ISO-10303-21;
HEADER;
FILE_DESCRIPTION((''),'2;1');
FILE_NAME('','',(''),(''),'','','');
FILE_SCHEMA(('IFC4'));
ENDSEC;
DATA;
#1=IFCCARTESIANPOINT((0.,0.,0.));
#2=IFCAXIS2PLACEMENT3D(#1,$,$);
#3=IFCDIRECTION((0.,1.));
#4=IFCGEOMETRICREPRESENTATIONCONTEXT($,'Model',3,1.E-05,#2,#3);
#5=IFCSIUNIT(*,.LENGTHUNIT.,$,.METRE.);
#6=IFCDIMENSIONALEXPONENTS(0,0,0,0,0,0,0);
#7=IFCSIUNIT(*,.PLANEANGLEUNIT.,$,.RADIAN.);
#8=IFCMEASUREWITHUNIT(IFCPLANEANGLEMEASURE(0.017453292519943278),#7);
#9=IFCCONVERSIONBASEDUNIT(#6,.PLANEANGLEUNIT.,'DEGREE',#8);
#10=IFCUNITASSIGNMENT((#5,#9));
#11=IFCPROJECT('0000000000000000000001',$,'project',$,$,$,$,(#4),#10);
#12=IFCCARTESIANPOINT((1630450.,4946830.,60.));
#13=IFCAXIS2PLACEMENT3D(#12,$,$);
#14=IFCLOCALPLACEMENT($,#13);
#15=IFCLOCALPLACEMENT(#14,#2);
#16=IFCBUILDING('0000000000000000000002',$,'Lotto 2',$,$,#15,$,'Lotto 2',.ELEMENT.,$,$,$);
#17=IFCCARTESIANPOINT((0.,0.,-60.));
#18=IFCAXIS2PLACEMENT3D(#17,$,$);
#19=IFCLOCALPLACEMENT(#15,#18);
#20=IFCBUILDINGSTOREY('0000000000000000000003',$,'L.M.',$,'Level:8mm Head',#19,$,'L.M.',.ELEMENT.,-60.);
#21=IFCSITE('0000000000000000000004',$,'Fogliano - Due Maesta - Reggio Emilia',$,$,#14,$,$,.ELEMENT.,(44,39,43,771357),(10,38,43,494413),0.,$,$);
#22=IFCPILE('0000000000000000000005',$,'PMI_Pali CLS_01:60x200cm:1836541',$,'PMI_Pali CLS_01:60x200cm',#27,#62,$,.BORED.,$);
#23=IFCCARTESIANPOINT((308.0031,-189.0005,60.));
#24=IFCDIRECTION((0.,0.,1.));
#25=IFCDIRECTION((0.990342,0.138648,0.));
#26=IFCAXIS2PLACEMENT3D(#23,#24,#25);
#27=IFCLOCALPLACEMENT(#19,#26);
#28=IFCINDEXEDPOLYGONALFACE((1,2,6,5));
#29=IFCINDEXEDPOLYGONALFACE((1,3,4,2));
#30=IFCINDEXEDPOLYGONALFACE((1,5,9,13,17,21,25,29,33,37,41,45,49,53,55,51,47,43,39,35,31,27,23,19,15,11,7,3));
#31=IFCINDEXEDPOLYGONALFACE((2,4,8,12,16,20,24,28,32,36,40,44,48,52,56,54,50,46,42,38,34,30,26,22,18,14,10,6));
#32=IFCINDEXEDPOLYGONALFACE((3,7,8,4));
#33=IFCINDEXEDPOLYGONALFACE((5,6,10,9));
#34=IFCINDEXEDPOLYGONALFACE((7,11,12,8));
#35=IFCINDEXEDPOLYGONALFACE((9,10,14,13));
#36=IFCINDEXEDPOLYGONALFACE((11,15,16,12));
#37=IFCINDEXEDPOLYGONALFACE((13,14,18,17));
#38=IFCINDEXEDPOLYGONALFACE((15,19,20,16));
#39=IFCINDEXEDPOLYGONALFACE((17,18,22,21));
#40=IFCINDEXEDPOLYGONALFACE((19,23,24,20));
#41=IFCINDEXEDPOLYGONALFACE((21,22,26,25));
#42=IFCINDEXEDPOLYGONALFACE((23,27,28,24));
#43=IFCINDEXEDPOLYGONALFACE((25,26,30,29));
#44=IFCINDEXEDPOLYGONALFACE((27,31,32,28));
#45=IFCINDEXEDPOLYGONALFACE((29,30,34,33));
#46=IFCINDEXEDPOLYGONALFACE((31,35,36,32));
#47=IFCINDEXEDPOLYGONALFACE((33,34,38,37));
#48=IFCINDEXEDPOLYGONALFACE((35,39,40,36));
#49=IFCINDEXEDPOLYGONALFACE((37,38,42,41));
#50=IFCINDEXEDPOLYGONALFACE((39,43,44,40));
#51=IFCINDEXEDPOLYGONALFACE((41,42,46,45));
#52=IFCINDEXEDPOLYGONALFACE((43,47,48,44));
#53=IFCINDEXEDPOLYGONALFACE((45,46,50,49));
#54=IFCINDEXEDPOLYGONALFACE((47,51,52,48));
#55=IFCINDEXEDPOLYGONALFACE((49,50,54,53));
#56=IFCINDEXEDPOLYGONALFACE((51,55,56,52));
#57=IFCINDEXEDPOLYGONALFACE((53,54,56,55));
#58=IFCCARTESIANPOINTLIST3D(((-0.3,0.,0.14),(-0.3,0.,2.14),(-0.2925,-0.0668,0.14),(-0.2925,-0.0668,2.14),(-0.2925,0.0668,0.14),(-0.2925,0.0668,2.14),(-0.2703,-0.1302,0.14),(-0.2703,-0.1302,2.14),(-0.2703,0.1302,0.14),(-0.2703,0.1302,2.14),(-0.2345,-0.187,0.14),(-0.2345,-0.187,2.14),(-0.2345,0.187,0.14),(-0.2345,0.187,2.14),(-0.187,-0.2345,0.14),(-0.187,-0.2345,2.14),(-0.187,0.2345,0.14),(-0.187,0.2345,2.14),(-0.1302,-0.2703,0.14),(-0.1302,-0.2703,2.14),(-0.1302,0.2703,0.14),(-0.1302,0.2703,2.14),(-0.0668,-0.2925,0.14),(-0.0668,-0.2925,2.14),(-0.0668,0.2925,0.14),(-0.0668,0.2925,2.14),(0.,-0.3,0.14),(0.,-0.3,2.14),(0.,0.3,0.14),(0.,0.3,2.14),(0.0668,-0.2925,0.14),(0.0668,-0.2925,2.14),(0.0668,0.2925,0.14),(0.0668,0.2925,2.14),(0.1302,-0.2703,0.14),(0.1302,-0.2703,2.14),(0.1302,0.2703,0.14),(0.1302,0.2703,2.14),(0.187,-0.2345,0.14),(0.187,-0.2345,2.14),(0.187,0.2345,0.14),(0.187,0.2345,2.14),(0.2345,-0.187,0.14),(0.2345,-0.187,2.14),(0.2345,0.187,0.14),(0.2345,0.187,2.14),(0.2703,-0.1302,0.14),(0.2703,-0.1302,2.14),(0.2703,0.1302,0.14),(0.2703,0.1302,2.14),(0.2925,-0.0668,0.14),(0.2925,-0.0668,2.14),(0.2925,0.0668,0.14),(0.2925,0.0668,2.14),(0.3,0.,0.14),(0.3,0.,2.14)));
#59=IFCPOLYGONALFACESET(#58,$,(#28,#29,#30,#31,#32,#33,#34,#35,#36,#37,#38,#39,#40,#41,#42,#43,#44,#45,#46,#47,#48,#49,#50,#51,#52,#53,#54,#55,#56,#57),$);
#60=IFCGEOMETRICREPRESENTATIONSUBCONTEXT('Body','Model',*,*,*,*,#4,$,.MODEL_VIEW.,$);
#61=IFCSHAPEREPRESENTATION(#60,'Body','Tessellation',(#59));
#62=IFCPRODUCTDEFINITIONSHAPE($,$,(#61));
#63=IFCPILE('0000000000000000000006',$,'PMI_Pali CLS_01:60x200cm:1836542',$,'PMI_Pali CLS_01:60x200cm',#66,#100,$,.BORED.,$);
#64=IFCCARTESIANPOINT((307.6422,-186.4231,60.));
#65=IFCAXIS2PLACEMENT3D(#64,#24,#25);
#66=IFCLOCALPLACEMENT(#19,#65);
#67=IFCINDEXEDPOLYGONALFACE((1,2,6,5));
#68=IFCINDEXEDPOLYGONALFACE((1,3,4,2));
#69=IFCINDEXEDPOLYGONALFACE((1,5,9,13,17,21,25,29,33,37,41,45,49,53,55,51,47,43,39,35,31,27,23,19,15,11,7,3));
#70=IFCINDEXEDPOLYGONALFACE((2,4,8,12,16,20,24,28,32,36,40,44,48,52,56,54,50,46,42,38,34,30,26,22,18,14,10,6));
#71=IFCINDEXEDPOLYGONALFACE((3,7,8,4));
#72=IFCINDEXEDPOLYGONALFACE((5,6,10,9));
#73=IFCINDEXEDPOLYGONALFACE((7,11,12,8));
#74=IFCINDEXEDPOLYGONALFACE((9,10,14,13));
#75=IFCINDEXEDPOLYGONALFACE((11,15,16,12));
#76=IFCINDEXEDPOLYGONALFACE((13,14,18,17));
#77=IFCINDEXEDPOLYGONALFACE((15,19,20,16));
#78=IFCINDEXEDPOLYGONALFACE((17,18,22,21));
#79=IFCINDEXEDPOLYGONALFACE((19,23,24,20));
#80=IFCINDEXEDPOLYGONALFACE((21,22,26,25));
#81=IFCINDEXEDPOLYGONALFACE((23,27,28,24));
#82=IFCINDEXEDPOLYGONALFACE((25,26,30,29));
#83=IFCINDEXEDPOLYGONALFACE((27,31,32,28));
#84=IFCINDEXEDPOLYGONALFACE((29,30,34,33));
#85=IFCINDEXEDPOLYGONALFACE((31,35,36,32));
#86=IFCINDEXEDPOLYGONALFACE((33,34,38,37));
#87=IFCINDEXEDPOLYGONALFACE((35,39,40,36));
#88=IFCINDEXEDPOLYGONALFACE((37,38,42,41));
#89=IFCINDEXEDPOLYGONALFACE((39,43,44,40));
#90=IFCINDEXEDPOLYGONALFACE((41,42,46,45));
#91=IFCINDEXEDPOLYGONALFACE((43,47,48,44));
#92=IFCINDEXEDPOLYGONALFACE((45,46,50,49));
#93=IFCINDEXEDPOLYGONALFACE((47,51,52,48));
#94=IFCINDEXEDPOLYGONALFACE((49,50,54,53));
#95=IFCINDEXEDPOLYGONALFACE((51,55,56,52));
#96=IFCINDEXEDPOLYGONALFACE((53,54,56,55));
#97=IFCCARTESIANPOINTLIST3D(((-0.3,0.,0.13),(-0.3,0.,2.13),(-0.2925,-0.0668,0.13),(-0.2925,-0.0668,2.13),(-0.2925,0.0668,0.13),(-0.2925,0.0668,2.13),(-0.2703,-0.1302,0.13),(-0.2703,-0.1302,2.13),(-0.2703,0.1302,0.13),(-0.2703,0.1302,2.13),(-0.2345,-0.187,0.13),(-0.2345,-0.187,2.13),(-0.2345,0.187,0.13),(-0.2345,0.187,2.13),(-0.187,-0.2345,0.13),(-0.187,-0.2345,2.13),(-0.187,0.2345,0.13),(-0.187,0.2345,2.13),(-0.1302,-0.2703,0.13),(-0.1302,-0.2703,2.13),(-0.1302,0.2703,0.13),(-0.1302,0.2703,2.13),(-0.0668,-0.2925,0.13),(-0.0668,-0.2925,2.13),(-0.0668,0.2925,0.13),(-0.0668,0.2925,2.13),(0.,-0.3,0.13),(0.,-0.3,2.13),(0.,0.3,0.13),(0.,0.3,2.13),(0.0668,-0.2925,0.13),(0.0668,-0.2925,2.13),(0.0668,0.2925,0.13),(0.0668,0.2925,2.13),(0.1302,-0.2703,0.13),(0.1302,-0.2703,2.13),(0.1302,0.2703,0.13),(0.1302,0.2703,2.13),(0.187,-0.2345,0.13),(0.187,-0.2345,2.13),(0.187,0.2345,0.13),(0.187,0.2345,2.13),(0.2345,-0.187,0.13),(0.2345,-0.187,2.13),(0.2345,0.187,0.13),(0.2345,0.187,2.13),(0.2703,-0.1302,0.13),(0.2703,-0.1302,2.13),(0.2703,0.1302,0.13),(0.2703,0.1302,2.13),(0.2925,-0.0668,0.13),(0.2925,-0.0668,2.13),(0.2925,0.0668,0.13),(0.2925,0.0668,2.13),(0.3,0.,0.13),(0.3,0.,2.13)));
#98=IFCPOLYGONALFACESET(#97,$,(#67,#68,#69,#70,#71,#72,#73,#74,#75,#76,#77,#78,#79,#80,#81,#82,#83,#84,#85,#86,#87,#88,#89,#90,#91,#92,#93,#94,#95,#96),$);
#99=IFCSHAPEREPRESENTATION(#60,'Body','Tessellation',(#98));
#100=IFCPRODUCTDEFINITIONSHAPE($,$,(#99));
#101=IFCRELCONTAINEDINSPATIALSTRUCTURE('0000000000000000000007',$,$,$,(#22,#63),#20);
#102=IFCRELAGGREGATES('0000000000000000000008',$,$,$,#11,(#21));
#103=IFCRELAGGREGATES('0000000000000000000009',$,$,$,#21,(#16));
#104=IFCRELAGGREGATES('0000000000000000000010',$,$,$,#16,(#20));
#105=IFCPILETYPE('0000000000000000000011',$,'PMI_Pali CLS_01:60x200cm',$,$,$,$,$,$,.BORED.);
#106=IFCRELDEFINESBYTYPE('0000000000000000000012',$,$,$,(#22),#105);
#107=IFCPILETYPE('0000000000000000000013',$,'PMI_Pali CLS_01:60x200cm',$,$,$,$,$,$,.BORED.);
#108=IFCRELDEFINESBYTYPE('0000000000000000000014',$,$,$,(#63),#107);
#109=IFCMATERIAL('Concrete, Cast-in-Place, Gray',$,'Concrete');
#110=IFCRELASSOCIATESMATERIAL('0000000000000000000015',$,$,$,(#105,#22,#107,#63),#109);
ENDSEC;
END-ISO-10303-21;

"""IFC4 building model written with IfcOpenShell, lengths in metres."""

from ifc_helpers import new_model, entity, si_unit, converted_unit, direction, frame, origin, place, context, subcontext, project, spatial, arc, indexed_curve, outline, extrude, source, transform, mapped, material, type_object, type_shapes, element, save


model = new_model("IFC4")

# Units and contexts
model_context = context("Model", 3, precision=1e-05, world=origin(), true_north=direction((0.0, 1.0)))
body_context = subcontext(model_context, "Body", "Model", "MODEL_VIEW")
ifc_project = project(units=[si_unit("LENGTHUNIT", "METRE"), converted_unit("PLANEANGLEUNIT", "DEGREE", entity("IfcPlaneAngleMeasure", 0.017453292519943278), si_unit("PLANEANGLEUNIT", "RADIAN"), dimensions=[0, 0, 0, 0, 0, 0, 0])], contexts=[model_context])

# Site, building, storey
site_placement = place(None, frame((1630450.0, 4946830.0, 60.0)))
site = spatial("IfcSite", under=ifc_project, at=site_placement, Name="Fogliano - Due Maesta - Reggio Emilia", CompositionType="ELEMENT", RefLatitude=(44, 39, 43, 771357), RefLongitude=(10, 38, 43, 494413), RefElevation=0.0)
building_placement = place(site_placement, origin())
building = spatial("IfcBuilding", under=site, at=building_placement, Name="Lotto 2", LongName="Lotto 2", CompositionType="ELEMENT")
storey_placement = place(building_placement, frame((0.0, 0.0, -60.0)))
storey = spatial("IfcBuildingStorey", under=building, at=storey_placement, Name="L.M.", ObjectType="Level:8mm Head", LongName="L.M.", CompositionType="ELEMENT", Elevation=-60.0)

# Piles
ifc_material_1 = material(Name="Concrete, Cast-in-Place, Gray", Category="Concrete")
pile_type_1 = type_object("IfcPileType", Name="PMI_Pali CLS_01:60x200cm", PredefinedType="BORED", material=ifc_material_1)
shared_shape_1 = source(origin(), body_context, "Body", "SweptSolid", [
    extrude(outline(indexed_curve([(-0.3, 0.0), (0.0, -0.3), (0.3, 0.0), (0.0, 0.3)], segments=[arc(1, 2, 3), arc(3, 4, 1)], self_intersect=False)), frame((0.0, 0.0, 0.14)), (0.0, 0.0, 1.0), 2.0),
])
type_shapes(pile_type_1, [shared_shape_1])
pile_1_placement = place(storey_placement, frame((308.0031, -189.0005, 60.0), z_axis=(0.0, 0.0, 1.0), x_axis=(0.990342, 0.138648, 0.0)))
element("IfcPile", 1, at=pile_1_placement, inside=storey, type_object=pile_type_1, material=ifc_material_1, Name="PMI_Pali CLS_01:60x200cm:1836541", ObjectType="PMI_Pali CLS_01:60x200cm", PredefinedType="BORED", context=body_context, shape_type="MappedRepresentation", body=[
    mapped(shared_shape_1, transform((0.0, 0.0, 0.0), scale=1.0)),
])
pile_type_2 = type_object("IfcPileType", Name="PMI_Pali CLS_01:60x200cm", PredefinedType="BORED", material=ifc_material_1)
shared_shape_2 = source(origin(), body_context, "Body", "SweptSolid", [
    extrude(outline(indexed_curve([(-0.3, 0.0), (0.0, -0.3), (0.3, 0.0), (0.0, 0.3)], segments=[arc(1, 2, 3), arc(3, 4, 1)], self_intersect=False)), frame((0.0, 0.0, 0.13)), (0.0, 0.0, 1.0), 2.0),
])
type_shapes(pile_type_2, [shared_shape_2])
pile_2_placement = place(storey_placement, frame((307.6422, -186.4231, 60.0), z_axis=(0.0, 0.0, 1.0), x_axis=(0.990342, 0.138648, 0.0)))
element("IfcPile", 2, at=pile_2_placement, inside=storey, type_object=pile_type_2, material=ifc_material_1, Name="PMI_Pali CLS_01:60x200cm:1836542", ObjectType="PMI_Pali CLS_01:60x200cm", PredefinedType="BORED", context=body_context, shape_type="MappedRepresentation", body=[
    mapped(shared_shape_2, transform((0.0, 0.0, 0.0), scale=1.0)),
])

save(model, "model.ifc")
